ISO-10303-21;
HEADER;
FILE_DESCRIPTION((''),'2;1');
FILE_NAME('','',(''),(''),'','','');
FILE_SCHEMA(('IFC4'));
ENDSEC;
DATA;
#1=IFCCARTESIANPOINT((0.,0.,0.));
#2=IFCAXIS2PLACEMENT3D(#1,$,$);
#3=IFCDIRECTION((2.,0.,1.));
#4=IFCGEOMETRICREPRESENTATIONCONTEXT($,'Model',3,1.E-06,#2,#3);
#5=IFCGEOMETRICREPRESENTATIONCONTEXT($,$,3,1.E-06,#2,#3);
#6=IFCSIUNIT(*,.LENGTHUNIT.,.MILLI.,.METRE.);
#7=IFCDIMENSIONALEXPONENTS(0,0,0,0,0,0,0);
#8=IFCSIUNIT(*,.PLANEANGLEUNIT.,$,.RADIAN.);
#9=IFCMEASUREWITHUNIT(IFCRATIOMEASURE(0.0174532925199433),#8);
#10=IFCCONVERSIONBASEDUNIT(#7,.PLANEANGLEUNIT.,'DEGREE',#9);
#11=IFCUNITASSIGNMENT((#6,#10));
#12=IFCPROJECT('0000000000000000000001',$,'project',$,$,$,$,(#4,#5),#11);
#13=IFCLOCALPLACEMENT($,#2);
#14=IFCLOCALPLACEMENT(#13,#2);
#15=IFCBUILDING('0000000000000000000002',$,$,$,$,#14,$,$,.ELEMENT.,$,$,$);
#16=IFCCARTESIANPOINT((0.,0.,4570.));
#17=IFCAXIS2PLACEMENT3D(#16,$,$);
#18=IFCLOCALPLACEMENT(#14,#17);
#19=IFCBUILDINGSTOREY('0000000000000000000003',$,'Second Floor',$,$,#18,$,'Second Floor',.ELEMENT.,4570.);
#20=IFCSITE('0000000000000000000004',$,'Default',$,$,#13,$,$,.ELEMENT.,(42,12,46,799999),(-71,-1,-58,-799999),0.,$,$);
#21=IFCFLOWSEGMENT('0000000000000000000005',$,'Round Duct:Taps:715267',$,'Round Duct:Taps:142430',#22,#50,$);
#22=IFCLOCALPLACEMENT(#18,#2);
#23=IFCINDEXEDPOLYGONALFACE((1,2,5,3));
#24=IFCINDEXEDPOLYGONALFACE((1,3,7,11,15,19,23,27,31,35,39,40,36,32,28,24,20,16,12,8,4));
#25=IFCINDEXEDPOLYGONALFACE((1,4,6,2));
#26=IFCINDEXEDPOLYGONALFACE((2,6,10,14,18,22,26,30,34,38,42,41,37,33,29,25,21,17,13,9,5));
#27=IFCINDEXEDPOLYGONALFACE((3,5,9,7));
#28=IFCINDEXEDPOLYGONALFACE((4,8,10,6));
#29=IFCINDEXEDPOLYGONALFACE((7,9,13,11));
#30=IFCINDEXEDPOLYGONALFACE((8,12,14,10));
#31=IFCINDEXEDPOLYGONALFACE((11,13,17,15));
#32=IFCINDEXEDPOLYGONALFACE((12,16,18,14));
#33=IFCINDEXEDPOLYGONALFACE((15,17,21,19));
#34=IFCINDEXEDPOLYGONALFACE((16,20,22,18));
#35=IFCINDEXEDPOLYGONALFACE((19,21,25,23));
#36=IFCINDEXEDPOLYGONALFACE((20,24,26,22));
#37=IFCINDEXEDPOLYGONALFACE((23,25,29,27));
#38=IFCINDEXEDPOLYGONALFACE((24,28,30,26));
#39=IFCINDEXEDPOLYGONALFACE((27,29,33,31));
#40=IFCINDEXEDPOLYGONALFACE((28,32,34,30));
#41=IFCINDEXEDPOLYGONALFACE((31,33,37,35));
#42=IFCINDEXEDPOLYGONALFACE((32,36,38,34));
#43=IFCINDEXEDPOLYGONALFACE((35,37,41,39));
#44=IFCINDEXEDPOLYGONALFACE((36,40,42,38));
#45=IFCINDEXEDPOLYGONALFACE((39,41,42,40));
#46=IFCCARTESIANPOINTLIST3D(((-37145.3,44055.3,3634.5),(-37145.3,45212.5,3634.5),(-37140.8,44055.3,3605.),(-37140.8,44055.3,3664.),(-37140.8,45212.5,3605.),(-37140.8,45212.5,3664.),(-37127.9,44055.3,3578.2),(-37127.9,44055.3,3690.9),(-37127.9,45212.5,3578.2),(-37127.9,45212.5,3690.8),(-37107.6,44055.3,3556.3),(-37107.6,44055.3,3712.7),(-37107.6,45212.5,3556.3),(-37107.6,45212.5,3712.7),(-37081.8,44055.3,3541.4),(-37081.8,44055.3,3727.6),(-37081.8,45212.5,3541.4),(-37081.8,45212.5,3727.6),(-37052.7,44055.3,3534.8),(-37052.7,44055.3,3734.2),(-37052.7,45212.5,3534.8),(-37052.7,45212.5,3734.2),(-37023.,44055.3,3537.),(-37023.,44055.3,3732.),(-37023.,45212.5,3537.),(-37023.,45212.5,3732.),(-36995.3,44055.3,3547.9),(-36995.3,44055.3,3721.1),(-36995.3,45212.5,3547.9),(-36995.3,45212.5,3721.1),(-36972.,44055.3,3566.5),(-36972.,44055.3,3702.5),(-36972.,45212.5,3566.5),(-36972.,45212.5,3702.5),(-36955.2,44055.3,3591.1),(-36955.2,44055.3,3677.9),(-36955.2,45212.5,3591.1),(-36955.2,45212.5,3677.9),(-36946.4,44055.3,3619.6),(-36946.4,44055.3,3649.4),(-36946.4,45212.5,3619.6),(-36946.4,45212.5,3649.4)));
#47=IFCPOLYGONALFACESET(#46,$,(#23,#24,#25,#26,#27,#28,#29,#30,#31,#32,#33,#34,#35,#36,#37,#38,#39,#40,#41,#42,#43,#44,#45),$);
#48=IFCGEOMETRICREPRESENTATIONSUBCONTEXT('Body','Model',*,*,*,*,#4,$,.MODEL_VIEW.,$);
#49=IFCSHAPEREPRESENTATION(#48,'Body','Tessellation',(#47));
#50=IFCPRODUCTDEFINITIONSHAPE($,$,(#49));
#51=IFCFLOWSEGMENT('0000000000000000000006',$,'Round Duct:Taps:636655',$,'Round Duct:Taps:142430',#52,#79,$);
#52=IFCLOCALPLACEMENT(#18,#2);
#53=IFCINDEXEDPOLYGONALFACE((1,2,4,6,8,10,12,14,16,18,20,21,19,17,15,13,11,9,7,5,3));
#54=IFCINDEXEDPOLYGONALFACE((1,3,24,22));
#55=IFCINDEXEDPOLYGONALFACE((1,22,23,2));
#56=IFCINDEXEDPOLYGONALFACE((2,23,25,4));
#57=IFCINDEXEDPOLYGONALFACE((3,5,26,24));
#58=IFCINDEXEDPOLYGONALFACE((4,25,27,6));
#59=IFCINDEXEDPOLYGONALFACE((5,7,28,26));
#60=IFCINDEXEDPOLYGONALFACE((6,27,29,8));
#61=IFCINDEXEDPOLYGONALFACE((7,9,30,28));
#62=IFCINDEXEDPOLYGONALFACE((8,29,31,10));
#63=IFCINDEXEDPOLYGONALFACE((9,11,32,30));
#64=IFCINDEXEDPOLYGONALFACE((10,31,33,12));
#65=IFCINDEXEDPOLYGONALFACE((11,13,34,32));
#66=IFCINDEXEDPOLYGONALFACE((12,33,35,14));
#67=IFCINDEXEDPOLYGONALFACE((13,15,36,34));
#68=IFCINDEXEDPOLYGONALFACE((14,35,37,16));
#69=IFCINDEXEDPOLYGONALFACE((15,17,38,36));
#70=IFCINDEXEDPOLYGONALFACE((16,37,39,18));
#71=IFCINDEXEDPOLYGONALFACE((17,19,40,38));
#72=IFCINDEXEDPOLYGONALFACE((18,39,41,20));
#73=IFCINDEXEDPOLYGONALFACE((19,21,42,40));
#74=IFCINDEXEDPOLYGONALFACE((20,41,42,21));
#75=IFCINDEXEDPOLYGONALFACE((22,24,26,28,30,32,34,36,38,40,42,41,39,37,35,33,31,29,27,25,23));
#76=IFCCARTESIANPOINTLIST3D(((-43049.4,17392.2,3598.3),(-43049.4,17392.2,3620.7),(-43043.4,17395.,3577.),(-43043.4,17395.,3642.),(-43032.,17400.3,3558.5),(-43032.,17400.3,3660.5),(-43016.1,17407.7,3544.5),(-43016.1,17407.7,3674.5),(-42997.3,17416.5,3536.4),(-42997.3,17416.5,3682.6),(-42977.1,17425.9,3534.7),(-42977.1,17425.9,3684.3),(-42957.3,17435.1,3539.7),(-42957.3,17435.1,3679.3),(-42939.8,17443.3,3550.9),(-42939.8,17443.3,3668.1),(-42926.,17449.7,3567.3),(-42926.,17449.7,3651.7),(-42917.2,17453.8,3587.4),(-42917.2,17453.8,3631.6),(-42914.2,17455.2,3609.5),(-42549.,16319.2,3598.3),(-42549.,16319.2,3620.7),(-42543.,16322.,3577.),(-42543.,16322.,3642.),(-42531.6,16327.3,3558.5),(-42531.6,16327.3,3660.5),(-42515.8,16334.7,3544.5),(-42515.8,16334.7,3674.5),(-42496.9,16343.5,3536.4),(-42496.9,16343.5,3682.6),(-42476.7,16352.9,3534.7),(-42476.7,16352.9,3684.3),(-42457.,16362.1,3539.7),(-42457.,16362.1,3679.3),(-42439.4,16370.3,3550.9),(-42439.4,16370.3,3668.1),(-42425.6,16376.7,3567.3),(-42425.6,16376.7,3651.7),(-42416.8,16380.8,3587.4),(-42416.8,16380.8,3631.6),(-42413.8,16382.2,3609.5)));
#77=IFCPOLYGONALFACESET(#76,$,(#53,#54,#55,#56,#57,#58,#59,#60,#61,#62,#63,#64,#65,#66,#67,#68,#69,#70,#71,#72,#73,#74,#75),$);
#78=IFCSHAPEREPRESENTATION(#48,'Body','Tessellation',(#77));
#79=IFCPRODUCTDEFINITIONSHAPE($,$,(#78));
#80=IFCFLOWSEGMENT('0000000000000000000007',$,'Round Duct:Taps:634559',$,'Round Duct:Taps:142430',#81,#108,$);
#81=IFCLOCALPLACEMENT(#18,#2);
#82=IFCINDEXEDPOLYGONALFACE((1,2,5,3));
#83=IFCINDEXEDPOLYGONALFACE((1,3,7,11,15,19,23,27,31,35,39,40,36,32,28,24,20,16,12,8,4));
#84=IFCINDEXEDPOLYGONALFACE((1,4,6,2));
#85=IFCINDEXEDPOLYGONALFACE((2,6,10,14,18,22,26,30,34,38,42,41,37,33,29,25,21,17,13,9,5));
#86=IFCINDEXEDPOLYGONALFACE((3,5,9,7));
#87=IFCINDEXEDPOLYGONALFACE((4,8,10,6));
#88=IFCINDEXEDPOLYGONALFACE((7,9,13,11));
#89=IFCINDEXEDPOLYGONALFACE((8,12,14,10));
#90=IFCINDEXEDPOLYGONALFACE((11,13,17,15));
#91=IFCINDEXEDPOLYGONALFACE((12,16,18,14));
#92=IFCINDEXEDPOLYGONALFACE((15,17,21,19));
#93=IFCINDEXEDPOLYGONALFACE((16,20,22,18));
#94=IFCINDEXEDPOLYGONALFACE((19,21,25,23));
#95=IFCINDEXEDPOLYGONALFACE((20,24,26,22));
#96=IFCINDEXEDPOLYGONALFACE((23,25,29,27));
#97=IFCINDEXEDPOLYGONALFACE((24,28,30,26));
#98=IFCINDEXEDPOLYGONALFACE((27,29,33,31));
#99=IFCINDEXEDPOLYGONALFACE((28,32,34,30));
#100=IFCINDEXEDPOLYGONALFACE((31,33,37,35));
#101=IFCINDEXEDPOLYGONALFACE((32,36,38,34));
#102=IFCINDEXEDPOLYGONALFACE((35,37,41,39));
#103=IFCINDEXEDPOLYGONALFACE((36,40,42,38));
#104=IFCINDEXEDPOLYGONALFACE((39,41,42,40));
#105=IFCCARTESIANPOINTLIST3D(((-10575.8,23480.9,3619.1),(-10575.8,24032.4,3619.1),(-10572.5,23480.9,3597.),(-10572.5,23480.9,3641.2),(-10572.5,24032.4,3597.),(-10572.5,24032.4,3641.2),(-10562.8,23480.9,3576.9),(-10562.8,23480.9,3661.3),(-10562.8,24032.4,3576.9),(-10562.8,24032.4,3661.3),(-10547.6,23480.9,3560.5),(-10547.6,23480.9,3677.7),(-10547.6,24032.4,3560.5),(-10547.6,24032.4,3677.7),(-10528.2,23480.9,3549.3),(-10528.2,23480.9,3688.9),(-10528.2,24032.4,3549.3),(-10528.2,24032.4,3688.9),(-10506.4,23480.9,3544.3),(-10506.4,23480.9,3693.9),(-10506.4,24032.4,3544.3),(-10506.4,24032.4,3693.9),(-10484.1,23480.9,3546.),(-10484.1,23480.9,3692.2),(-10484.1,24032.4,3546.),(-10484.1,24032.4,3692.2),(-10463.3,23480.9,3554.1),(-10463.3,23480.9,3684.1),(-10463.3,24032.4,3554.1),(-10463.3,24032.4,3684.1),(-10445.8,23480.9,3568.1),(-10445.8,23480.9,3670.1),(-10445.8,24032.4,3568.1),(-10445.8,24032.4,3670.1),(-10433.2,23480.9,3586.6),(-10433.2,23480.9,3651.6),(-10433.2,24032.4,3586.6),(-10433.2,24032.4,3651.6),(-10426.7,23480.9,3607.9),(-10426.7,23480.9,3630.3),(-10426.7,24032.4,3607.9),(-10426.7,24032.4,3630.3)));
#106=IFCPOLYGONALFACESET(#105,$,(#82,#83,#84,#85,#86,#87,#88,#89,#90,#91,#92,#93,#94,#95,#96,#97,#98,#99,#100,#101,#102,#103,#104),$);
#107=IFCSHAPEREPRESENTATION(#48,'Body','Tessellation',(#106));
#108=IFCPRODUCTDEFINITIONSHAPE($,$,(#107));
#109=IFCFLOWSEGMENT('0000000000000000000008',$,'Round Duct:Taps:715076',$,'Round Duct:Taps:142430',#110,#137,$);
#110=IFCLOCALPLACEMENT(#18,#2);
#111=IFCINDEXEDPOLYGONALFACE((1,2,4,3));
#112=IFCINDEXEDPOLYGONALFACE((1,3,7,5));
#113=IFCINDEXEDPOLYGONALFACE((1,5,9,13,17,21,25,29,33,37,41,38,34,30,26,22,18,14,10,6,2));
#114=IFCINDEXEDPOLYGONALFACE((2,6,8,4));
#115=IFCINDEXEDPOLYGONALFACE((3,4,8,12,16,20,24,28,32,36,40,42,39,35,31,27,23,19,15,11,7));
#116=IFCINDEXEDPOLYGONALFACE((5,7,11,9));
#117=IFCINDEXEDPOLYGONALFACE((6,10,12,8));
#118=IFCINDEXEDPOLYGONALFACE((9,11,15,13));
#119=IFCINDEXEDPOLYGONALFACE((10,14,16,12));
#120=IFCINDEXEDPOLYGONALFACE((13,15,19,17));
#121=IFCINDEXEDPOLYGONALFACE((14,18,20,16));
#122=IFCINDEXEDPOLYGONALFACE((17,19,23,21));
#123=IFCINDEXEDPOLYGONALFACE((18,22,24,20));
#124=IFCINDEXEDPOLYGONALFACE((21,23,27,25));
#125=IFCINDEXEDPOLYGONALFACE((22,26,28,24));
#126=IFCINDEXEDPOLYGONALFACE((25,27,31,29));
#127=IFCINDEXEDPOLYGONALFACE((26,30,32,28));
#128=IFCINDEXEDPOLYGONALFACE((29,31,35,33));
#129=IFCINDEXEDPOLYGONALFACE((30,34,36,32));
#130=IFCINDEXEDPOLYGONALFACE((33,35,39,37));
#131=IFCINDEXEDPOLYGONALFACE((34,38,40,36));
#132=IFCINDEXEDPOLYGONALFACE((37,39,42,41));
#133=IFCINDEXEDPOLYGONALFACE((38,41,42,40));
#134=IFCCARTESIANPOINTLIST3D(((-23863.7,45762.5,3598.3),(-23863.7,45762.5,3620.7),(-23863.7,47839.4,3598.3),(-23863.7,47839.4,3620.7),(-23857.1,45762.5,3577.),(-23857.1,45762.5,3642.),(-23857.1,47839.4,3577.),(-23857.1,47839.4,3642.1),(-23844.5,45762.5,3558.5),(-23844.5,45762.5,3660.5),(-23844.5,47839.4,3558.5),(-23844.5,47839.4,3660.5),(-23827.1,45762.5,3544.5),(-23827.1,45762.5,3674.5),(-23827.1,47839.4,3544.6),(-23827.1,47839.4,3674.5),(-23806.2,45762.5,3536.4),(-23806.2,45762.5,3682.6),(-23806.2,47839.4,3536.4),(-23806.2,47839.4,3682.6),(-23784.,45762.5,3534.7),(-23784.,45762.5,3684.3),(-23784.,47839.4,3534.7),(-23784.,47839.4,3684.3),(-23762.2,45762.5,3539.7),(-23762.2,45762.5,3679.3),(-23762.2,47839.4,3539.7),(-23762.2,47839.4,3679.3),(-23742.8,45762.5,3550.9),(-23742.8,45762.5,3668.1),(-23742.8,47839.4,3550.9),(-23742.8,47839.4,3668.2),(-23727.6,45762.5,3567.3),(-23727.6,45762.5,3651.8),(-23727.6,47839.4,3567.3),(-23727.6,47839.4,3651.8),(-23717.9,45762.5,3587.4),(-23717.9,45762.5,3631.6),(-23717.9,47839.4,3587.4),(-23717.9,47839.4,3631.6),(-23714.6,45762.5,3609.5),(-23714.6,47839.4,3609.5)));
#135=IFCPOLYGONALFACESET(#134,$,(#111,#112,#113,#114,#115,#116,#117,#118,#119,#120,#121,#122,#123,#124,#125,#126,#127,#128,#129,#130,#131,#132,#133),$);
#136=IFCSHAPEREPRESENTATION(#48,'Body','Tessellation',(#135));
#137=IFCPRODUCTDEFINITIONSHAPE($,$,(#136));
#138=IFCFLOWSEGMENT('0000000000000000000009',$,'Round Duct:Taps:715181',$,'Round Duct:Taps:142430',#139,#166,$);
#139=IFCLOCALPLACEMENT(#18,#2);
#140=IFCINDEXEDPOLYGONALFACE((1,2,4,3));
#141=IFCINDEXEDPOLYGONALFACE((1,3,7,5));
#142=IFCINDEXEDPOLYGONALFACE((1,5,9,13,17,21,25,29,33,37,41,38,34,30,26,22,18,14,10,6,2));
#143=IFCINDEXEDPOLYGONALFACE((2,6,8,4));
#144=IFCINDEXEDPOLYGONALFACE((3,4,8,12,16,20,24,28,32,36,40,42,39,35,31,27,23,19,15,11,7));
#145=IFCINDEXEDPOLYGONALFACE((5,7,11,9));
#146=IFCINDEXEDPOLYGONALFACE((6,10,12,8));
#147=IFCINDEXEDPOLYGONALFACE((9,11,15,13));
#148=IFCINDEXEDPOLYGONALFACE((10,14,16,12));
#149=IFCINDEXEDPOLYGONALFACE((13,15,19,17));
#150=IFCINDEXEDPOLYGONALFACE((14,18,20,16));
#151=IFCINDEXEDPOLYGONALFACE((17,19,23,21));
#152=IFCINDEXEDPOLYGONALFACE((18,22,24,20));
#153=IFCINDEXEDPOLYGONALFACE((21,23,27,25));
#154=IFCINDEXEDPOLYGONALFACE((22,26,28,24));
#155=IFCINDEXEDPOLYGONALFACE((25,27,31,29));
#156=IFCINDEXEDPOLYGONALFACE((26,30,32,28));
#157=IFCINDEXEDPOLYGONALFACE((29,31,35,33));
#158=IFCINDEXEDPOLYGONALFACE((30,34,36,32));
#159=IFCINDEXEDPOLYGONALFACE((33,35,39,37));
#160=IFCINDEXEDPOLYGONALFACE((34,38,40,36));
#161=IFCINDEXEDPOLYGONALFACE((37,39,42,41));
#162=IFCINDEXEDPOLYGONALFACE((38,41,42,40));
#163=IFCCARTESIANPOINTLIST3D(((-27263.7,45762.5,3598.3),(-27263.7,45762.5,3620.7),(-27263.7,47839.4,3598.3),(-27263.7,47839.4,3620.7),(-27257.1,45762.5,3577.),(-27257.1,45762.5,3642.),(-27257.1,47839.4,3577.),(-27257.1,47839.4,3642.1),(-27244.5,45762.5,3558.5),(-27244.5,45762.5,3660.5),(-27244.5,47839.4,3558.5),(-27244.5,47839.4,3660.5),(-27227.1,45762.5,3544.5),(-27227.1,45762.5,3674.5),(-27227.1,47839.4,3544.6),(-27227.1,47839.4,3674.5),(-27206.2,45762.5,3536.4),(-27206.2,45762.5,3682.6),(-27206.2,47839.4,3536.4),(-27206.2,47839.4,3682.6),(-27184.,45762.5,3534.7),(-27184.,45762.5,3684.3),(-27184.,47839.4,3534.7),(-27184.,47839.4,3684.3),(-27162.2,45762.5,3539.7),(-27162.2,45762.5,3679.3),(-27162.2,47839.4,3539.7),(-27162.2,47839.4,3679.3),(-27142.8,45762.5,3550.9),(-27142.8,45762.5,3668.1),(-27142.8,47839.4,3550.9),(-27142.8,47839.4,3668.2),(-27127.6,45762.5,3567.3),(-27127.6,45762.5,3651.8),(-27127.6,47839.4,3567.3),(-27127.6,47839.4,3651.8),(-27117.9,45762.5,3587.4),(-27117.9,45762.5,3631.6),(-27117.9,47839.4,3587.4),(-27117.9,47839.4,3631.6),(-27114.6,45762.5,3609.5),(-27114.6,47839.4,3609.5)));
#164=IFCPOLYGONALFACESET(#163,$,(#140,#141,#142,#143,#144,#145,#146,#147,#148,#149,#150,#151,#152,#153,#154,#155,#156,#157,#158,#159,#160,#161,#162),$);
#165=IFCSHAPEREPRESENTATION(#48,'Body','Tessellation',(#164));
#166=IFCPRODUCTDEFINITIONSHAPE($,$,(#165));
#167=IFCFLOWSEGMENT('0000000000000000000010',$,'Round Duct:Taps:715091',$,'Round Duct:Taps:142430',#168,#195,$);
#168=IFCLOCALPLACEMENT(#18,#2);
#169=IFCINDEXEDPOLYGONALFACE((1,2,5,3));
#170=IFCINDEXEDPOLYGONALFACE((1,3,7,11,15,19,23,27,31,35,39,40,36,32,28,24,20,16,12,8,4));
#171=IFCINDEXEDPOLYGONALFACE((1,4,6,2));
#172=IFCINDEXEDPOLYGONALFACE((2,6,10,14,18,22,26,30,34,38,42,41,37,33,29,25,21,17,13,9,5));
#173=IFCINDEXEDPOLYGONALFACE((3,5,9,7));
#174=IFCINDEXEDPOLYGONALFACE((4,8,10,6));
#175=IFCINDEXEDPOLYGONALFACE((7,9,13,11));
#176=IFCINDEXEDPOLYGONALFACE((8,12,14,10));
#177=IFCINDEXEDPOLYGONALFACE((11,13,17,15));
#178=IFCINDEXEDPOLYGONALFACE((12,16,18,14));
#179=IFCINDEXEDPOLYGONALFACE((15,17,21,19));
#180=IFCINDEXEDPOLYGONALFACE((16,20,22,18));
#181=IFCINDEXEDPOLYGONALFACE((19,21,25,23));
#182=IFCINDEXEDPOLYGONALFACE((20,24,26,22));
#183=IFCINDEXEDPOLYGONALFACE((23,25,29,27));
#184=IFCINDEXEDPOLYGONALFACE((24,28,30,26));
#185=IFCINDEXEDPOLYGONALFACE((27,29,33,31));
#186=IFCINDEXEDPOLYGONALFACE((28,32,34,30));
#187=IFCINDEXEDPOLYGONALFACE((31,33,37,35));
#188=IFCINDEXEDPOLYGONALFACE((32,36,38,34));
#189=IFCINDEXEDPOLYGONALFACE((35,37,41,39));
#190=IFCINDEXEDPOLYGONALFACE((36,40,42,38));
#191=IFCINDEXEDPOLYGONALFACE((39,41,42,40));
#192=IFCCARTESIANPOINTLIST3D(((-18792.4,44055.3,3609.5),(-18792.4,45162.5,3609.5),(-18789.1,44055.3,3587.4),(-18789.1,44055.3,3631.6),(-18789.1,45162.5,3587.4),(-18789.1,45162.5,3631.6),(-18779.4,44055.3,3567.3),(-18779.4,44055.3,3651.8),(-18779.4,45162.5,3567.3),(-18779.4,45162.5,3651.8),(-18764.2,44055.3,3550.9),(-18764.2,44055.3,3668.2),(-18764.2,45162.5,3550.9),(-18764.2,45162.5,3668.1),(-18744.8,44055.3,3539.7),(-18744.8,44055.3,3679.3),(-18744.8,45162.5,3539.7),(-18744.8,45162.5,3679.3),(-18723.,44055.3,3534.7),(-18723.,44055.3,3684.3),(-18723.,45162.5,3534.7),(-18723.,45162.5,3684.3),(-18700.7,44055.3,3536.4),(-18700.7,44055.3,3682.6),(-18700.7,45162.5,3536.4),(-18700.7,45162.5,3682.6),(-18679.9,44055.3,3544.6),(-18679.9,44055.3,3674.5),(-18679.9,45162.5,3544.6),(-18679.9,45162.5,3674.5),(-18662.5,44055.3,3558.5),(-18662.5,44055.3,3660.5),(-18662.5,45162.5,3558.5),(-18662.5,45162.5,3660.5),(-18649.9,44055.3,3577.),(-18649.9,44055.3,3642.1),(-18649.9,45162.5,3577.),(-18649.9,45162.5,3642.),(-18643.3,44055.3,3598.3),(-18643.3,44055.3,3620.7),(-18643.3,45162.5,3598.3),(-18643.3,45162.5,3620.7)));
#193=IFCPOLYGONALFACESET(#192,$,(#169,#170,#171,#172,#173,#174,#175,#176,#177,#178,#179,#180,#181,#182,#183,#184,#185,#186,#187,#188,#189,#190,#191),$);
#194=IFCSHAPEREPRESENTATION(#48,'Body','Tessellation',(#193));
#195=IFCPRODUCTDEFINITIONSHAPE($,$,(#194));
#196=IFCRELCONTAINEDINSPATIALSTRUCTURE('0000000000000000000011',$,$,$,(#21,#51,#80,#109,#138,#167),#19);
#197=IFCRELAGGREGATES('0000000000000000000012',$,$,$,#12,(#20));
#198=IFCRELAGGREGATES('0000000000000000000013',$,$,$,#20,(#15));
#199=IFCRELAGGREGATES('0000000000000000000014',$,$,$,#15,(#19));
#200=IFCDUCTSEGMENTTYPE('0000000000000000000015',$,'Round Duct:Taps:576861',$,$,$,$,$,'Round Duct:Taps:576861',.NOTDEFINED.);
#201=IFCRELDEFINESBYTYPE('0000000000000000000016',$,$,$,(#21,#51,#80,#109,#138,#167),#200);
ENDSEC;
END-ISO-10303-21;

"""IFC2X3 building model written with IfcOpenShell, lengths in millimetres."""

from ifc_helpers import new_model, entity, si_unit, converted_unit, direction, frame, frame_2d, origin, origin_2d_with_axis, place, context, subcontext, project, spatial, circle, extrude, type_object, element, save


model = new_model("IFC2X3")

# Units and contexts
model_context = context("Model", 3, precision=1e-06, world=origin(), true_north=direction((2.0, 0.0, 1.0)))
context_of_model = context(None, 3, precision=1e-06, world=origin(), true_north=direction((2.0, 0.0, 1.0)))
body_context = subcontext(model_context, "Body", "Model", "MODEL_VIEW")
ifc_project = project(units=[si_unit("LENGTHUNIT", "METRE", prefix="MILLI"), converted_unit("PLANEANGLEUNIT", "DEGREE", entity("IfcRatioMeasure", 0.0174532925199433), si_unit("PLANEANGLEUNIT", "RADIAN"), dimensions=[0, 0, 0, 0, 0, 0, 0])], contexts=[model_context, context_of_model])

# Site, building, storey
site_placement = place(None, origin())
site = spatial("IfcSite", under=ifc_project, at=site_placement, Name="Default", CompositionType="ELEMENT", RefLatitude=(42, 12, 46, 799999), RefLongitude=(-71, -1, -58, -799999), RefElevation=0.0)
building_placement = place(site_placement, origin())
building = spatial("IfcBuilding", under=site, at=building_placement, CompositionType="ELEMENT")
storey_placement = place(building_placement, frame((0.0, 0.0, 4570.0)))
storey = spatial("IfcBuildingStorey", under=building, at=storey_placement, Name="Second Floor", LongName="Second Floor", CompositionType="ELEMENT", Elevation=4570.0)

# Flow segments
duct_segment_type_1 = type_object("IfcDuctSegmentType", Name="Round Duct:Taps:576861", ElementType="Round Duct:Taps:576861", PredefinedType="NOTDEFINED")
flow_segment_1_placement = place(storey_placement, origin())
element("IfcFlowSegment", 1, at=flow_segment_1_placement, inside=storey, type_object=duct_segment_type_1, Name="Round Duct:Taps:715267", ObjectType="Round Duct:Taps:142430", context=body_context, shape_type="SweptSolid", body=[
    extrude(circle(Radius=100.0, at=frame_2d((0.0, 0.0), x_axis=(1.0, 0.0))), frame((-37045.3, 44055.3, 3634.5), z_axis=(0.0, 1.0, -0.00002), x_axis=(-1.0, 0.0, 0.0)), (0.0, 0.0, 1.0), 1157.2),
])
flow_segment_2_placement = place(storey_placement, origin())
element("IfcFlowSegment", 2, at=flow_segment_2_placement, inside=storey, type_object=duct_segment_type_1, Name="Round Duct:Taps:636655", ObjectType="Round Duct:Taps:142430", context=body_context, shape_type="SweptSolid", body=[
    extrude(circle(Radius=75.0, at=origin_2d_with_axis()), frame((-42982.2, 17423.5, 3609.5), z_axis=(0.422618, -0.906308, 0.0), x_axis=(0.906308, 0.422618, 0.0)), (0.0, 0.0, 1.0), 1183.9),
])
flow_segment_3_placement = place(storey_placement, origin())
element("IfcFlowSegment", 3, at=flow_segment_3_placement, inside=storey, type_object=duct_segment_type_1, Name="Round Duct:Taps:634559", ObjectType="Round Duct:Taps:142430", context=body_context, shape_type="SweptSolid", body=[
    extrude(circle(Radius=75.0, at=frame_2d((0.0, 0.0), x_axis=(1.0, 0.0))), frame((-10500.8, 23480.9, 3619.1), z_axis=(0.0, 1.0, 0.0), x_axis=(-1.0, 0.0, 0.0)), (0.0, 0.0, 1.0), 551.6),
])
flow_segment_4_placement = place(storey_placement, origin())
element("IfcFlowSegment", 4, at=flow_segment_4_placement, inside=storey, type_object=duct_segment_type_1, Name="Round Duct:Taps:715076", ObjectType="Round Duct:Taps:142430", context=body_context, shape_type="SweptSolid", body=[
    extrude(circle(Radius=75.0, at=origin_2d_with_axis()), frame((-23789.6, 45762.5, 3609.5), z_axis=(0.0, 1.0, 0.000011), x_axis=(1.0, 0.0, 0.0)), (0.0, 0.0, 1.0), 2077.0),
])
flow_segment_5_placement = place(storey_placement, origin())
element("IfcFlowSegment", 5, at=flow_segment_5_placement, inside=storey, type_object=duct_segment_type_1, Name="Round Duct:Taps:715181", ObjectType="Round Duct:Taps:142430", context=body_context, shape_type="SweptSolid", body=[
    extrude(circle(Radius=75.0, at=origin_2d_with_axis()), frame((-27189.6, 45762.5, 3609.5), z_axis=(0.0, 1.0, 0.000011), x_axis=(1.0, 0.0, 0.0)), (0.0, 0.0, 1.0), 2077.0),
])
flow_segment_6_placement = place(storey_placement, origin())
element("IfcFlowSegment", 6, at=flow_segment_6_placement, inside=storey, type_object=duct_segment_type_1, Name="Round Duct:Taps:715091", ObjectType="Round Duct:Taps:142430", context=body_context, shape_type="SweptSolid", body=[
    extrude(circle(Radius=75.0, at=origin_2d_with_axis()), frame((-18717.4, 45162.5, 3609.5), z_axis=(0.0, -1.0, 0.000021), x_axis=(-1.0, 0.0, 0.0)), (0.0, 0.0, 1.0), 1107.2),
])

save(model, "model.ifc")
